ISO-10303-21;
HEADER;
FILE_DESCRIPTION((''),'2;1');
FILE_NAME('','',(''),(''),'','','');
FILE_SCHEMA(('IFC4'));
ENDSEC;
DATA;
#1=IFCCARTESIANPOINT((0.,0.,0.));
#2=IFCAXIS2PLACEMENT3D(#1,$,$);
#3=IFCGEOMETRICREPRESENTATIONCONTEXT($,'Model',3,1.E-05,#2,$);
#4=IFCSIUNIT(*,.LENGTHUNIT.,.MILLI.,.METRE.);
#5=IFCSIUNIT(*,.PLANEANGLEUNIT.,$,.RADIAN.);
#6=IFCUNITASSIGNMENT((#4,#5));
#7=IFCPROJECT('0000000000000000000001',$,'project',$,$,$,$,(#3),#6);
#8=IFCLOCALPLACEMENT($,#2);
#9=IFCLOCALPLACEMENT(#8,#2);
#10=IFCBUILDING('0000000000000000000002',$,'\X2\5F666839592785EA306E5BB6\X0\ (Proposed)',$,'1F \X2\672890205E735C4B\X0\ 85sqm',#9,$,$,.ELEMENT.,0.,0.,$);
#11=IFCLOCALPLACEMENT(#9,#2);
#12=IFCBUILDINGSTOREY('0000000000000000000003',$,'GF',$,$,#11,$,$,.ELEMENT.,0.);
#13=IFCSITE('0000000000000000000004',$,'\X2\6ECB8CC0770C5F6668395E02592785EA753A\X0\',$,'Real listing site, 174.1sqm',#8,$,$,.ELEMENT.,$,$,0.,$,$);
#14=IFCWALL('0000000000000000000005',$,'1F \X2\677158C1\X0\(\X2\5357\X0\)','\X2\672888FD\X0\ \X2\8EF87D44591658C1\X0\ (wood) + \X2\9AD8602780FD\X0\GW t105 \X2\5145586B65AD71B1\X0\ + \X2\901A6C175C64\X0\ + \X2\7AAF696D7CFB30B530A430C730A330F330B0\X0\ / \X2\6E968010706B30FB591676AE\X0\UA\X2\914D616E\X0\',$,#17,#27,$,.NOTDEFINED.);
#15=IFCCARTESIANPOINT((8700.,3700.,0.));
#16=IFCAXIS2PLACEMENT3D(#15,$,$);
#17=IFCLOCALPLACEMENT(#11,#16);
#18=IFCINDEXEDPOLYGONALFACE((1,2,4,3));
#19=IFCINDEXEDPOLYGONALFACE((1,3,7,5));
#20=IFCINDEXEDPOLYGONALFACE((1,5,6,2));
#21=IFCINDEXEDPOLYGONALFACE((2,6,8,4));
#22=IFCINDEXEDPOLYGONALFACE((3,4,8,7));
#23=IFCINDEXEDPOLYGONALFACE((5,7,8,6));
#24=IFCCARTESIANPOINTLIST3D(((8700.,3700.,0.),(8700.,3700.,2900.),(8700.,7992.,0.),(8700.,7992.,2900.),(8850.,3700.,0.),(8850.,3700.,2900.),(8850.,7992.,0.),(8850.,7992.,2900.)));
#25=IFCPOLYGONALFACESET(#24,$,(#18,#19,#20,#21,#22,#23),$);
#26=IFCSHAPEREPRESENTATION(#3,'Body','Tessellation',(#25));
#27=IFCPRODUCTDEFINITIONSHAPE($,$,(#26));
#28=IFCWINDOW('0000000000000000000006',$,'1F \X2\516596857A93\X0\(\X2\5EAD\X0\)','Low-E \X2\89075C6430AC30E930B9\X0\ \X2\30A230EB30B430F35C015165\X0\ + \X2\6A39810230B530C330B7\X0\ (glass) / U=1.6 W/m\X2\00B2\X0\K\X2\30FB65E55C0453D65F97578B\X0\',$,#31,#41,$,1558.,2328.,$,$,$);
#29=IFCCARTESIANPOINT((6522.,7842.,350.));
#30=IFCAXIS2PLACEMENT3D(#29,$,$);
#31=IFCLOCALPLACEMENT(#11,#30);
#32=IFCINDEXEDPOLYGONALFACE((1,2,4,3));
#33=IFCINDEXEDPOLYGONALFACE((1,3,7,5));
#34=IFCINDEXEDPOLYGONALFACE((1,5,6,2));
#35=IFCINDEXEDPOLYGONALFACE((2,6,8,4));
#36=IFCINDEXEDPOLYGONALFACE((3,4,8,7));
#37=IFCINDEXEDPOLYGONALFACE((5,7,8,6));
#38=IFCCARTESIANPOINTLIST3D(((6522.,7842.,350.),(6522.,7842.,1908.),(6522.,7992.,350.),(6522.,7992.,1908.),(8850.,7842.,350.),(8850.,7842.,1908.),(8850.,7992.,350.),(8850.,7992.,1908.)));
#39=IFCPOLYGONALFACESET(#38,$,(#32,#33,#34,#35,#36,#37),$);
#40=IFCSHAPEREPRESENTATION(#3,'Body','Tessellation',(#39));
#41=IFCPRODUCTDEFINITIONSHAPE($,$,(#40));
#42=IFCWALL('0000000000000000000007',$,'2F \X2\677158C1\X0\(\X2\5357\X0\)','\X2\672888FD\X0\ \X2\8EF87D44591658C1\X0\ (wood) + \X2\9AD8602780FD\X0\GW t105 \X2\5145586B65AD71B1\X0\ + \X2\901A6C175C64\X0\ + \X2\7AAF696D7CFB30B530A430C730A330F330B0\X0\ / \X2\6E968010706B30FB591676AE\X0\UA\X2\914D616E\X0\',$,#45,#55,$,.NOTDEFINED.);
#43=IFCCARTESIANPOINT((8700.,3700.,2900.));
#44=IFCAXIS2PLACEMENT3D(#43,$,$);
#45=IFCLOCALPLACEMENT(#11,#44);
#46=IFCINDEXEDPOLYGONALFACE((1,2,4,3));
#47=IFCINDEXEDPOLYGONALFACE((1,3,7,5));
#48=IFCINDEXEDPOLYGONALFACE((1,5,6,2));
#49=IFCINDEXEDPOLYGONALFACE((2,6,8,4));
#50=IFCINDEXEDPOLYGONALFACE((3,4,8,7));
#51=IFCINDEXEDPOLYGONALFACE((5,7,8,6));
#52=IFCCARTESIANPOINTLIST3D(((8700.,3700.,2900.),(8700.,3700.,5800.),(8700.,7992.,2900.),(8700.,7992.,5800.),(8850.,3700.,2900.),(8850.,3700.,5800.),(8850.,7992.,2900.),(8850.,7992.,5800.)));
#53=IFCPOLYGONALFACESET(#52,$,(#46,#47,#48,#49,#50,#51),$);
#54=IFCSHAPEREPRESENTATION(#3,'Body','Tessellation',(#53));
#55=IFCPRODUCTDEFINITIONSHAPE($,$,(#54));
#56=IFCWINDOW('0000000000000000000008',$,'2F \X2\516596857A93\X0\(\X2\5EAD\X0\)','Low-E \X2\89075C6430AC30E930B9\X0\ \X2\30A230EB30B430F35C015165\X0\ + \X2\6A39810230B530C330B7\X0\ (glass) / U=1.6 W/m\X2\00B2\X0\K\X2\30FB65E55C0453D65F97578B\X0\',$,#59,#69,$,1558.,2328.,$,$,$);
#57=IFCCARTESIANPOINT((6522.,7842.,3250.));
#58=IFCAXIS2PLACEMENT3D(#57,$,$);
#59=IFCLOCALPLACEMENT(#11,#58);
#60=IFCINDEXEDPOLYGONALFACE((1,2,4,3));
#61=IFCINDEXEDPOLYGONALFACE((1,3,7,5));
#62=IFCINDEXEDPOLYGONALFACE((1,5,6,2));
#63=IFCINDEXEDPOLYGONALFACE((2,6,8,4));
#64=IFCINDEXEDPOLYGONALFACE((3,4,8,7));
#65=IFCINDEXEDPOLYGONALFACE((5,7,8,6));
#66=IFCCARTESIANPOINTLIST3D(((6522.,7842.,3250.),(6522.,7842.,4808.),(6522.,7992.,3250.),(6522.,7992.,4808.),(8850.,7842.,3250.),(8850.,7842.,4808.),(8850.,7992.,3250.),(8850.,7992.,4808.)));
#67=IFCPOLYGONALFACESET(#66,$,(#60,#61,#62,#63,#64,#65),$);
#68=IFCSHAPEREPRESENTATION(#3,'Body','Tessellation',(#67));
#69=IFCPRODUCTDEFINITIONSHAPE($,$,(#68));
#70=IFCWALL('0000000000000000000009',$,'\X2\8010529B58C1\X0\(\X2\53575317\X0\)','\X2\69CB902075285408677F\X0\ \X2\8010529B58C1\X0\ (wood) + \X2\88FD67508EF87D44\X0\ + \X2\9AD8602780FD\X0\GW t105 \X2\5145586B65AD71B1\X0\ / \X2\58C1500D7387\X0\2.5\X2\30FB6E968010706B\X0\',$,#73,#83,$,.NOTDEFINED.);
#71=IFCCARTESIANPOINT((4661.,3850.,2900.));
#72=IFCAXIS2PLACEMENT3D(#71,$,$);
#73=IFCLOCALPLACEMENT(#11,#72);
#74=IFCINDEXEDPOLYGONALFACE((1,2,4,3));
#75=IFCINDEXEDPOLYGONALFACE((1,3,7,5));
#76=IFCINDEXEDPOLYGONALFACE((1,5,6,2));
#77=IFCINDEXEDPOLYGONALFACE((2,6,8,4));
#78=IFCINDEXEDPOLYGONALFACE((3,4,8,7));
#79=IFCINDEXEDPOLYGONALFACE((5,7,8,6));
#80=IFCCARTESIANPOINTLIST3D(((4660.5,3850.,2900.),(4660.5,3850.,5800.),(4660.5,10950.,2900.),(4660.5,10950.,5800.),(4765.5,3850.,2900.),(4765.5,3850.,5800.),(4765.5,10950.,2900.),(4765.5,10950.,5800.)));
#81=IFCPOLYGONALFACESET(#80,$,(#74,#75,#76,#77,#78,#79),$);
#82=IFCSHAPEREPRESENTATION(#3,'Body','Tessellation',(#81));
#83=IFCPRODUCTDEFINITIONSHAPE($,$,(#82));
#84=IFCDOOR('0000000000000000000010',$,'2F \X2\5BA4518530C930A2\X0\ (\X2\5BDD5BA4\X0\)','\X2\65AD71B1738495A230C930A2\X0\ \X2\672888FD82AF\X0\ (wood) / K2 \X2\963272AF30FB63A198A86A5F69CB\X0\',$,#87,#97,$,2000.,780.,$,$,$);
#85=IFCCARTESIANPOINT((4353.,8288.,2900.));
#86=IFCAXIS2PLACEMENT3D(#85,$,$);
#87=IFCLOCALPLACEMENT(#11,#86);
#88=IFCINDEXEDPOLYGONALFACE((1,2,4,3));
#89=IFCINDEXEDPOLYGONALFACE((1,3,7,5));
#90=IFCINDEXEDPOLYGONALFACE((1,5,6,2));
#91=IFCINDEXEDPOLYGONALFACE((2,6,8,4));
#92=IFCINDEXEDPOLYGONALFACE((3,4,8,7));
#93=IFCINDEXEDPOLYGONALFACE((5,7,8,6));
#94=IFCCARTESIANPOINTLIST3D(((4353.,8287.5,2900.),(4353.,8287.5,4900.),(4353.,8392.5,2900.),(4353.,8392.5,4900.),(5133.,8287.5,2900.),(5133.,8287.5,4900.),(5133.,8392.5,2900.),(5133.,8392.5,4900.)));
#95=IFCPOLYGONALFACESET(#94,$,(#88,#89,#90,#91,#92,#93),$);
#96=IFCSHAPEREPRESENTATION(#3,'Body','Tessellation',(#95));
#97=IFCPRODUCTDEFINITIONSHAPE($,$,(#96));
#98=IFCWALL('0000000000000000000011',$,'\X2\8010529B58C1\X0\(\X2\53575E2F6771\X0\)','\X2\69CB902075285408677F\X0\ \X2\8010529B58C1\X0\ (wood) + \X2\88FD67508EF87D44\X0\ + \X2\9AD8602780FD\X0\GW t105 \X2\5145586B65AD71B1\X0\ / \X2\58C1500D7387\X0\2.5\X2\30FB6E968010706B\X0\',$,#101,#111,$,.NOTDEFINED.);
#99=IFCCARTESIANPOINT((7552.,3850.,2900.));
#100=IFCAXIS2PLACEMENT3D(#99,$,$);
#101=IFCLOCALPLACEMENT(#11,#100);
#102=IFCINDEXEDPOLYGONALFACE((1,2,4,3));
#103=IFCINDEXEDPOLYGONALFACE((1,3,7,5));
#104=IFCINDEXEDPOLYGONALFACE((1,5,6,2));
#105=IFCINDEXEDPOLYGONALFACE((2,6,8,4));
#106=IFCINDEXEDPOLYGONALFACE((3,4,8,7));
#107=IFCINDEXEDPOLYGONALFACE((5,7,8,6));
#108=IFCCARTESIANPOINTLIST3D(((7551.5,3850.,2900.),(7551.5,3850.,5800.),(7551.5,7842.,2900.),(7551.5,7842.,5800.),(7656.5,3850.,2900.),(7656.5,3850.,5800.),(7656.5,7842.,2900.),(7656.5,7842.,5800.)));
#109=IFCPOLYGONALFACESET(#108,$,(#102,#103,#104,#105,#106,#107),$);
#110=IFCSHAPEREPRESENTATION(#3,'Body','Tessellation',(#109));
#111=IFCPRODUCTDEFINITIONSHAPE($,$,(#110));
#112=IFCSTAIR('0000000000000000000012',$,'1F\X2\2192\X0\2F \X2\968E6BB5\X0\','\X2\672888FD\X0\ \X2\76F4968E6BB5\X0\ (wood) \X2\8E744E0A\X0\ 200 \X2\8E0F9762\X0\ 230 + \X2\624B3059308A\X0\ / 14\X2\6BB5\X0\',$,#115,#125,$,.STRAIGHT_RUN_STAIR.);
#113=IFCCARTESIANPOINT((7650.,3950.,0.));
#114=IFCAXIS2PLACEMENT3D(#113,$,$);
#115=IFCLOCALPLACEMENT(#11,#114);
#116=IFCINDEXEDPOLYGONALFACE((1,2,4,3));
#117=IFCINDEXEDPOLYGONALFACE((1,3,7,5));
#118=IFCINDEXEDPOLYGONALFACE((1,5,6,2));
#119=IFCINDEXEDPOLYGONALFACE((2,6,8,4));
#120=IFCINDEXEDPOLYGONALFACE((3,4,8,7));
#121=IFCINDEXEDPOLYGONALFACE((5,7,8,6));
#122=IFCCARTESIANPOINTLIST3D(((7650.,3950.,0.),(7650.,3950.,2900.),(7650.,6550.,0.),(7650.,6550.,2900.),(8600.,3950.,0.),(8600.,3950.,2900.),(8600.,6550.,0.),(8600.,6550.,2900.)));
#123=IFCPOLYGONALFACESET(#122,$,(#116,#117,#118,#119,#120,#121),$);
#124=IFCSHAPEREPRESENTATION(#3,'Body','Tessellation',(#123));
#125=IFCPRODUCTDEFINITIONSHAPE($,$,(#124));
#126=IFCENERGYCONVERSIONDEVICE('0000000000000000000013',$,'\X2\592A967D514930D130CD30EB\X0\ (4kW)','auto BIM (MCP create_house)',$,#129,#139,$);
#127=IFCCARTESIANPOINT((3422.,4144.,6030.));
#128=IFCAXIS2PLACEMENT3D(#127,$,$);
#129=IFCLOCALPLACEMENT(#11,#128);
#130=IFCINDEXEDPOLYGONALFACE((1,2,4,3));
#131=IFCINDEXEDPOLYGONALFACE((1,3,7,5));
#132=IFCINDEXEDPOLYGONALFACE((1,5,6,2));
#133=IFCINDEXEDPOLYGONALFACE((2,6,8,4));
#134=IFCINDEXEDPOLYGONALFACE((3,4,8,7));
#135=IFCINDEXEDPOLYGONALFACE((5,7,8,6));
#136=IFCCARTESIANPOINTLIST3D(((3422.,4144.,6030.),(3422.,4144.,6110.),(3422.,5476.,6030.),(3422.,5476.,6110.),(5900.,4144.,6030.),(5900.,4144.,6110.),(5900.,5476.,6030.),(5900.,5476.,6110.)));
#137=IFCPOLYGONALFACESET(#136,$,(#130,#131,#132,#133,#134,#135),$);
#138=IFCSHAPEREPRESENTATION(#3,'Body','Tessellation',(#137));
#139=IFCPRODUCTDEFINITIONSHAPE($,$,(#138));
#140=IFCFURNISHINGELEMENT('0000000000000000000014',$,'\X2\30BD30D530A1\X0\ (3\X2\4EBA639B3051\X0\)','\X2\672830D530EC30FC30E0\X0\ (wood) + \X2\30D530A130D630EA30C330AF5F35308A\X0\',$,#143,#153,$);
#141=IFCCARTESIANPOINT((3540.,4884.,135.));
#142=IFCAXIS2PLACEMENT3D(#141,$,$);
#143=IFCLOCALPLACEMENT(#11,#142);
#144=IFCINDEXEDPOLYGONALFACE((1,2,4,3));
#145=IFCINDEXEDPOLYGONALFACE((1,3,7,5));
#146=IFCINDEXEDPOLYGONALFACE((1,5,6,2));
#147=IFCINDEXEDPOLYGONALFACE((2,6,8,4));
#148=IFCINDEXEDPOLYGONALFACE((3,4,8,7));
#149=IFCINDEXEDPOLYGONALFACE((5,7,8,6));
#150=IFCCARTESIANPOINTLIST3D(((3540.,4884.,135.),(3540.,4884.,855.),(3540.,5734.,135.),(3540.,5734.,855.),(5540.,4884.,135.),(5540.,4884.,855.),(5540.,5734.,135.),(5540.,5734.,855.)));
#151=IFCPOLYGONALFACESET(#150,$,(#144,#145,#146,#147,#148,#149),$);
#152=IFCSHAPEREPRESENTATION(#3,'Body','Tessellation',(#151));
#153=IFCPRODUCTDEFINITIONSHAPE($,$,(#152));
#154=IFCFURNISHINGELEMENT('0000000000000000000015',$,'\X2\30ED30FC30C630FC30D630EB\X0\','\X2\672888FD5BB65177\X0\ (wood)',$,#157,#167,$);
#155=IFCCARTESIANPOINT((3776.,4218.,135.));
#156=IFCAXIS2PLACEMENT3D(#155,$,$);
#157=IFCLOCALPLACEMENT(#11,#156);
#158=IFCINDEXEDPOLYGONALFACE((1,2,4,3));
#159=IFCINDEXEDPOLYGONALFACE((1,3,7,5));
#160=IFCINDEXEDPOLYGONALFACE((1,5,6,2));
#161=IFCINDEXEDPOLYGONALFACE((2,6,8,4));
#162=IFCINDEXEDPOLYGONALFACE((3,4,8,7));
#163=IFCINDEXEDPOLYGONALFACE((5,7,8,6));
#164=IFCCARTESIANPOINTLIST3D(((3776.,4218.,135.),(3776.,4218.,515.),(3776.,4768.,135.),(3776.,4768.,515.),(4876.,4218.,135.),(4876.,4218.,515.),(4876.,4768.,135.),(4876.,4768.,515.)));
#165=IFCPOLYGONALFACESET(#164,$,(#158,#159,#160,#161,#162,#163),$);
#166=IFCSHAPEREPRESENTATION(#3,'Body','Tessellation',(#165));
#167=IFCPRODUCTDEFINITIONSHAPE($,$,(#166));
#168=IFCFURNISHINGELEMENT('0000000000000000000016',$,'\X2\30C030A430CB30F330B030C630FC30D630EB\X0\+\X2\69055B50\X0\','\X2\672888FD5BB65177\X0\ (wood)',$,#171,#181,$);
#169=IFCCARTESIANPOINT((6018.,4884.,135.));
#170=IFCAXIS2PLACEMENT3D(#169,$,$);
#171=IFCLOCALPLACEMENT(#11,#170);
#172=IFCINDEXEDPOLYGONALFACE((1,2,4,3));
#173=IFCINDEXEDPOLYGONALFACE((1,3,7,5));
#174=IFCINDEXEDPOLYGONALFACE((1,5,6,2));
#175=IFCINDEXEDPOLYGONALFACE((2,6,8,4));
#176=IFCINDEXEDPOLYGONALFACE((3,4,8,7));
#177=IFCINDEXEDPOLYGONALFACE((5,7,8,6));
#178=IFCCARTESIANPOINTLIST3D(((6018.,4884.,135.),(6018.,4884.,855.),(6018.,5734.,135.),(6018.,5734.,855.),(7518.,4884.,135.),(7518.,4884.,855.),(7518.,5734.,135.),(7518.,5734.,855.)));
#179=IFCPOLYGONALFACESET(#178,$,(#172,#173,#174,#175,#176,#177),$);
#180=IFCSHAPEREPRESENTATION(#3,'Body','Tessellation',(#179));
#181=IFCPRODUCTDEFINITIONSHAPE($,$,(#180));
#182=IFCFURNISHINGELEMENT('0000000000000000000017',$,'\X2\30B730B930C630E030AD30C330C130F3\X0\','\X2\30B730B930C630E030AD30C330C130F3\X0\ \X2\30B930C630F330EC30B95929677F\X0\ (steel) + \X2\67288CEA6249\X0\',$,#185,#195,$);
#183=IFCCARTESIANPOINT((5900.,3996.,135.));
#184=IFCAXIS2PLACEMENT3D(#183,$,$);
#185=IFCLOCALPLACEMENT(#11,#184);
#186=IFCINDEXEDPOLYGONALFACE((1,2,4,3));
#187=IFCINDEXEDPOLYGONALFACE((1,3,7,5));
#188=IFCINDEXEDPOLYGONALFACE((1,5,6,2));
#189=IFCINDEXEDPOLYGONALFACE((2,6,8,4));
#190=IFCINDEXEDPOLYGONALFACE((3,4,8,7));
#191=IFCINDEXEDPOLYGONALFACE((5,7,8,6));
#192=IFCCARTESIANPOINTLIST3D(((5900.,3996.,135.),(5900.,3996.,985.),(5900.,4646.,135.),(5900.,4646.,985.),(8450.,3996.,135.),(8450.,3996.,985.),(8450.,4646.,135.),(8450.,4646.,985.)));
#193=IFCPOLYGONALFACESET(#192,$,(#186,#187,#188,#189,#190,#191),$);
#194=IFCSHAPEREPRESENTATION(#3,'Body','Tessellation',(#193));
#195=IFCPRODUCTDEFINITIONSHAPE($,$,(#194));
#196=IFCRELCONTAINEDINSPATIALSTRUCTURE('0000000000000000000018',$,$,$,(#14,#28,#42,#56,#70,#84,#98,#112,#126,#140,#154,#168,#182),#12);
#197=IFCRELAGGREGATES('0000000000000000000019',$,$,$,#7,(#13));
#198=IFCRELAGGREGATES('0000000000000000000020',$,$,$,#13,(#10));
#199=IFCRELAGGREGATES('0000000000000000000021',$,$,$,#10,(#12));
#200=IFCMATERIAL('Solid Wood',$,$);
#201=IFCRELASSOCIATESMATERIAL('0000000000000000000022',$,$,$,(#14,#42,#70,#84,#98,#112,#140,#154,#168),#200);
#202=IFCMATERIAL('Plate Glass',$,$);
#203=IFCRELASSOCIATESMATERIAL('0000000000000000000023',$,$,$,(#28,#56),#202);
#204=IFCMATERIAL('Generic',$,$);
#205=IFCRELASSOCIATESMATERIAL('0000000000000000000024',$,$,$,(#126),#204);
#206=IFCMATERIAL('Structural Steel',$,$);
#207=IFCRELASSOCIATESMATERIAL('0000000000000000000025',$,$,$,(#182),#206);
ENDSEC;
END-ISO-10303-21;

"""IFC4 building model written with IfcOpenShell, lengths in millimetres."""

from ifc_helpers import new_model, si_unit, frame, frame_2d, origin, place, context, project, spatial, rectangle, extrude, material, element, fill, save


model = new_model("IFC4")

# Units and contexts
model_context = context("Model", 3, precision=1e-05, world=origin())
ifc_project = project(units=[si_unit("LENGTHUNIT", "METRE", prefix="MILLI"), si_unit("PLANEANGLEUNIT", "RADIAN")], contexts=[model_context])

# Site, building, storey
site_placement = place(None, origin())
site = spatial("IfcSite", under=ifc_project, at=site_placement, Name="滋賀県彦根市大藪町", ObjectType="Real listing site, 174.1sqm", CompositionType="ELEMENT", RefElevation=0.0)
building_placement = place(site_placement, origin())
building = spatial("IfcBuilding", under=site, at=building_placement, Name="彦根大藪の家 (Proposed)", ObjectType="1F 木造平屋 85sqm", CompositionType="ELEMENT", ElevationOfRefHeight=0.0, ElevationOfTerrain=0.0)
storey_placement = place(building_placement, origin())
storey = spatial("IfcBuildingStorey", under=building, at=storey_placement, Name="GF", CompositionType="ELEMENT", Elevation=0.0)

# Wall, opening, window
ifc_material_1 = material(Name="Solid Wood")
wall_1_placement = place(storey_placement, frame((8700.0, 3700.0, 0.0)))
wall_1 = element("IfcWall", 1, at=wall_1_placement, inside=storey, material=ifc_material_1, Name="1F 東壁(南)", Description="木製 軸組外壁 (wood) + 高性能GW t105 充填断熱 + 通気層 + 窯業系サイディング / 準耐火・外皮UA配慮", PredefinedType="NOTDEFINED", context=model_context, shape_type="SweptSolid", body=[
    extrude(rectangle(XDim=150.0, YDim=4292.0, at=frame_2d((75.0, 2146.0))), frame((8700.0, 3700.0, 0.0)), (0.0, 0.0, 1.0), 2900.0),
])
opening_1_placement = place(storey_placement, frame((6522.0, 7842.0, 350.0)))
opening_1 = element("IfcOpeningElement", 2, at=opening_1_placement, cuts=wall_1, PredefinedType="NOTDEFINED", context=model_context, shape_type="SweptSolid", body=[
    extrude(rectangle(XDim=2328.0, YDim=150.0, at=frame_2d((1164.0, 75.0))), frame((6522.0, 7842.0, 350.0)), (0.0, 0.0, 1.0), 1558.0),
])
ifc_material_2 = material(Name="Plate Glass")
window_1_placement = place(storey_placement, frame((6522.0, 7842.0, 350.0)))
window_1 = element("IfcWindow", 3, at=window_1_placement, inside=storey, material=ifc_material_2, Name="1F 入隅窓(庭)", Description="Low-E 複層ガラス アルゴン封入 + 樹脂サッシ (glass) / U=1.6 W/m²K・日射取得型", OverallHeight=1558.0, OverallWidth=2328.0, context=model_context, shape_type="SweptSolid", body=[
    extrude(rectangle(XDim=2328.0, YDim=150.0, at=frame_2d((1164.0, 75.0))), frame((6522.0, 7842.0, 350.0)), (0.0, 0.0, 1.0), 1558.0),
])
fill(opening_1, window_1)

# Wall, opening, window
wall_2_placement = place(storey_placement, frame((8700.0, 3700.0, 2900.0)))
wall_2 = element("IfcWall", 4, at=wall_2_placement, inside=storey, material=ifc_material_1, Name="2F 東壁(南)", Description="木製 軸組外壁 (wood) + 高性能GW t105 充填断熱 + 通気層 + 窯業系サイディング / 準耐火・外皮UA配慮", PredefinedType="NOTDEFINED", context=model_context, shape_type="SweptSolid", body=[
    extrude(rectangle(XDim=150.0, YDim=4292.0, at=frame_2d((75.0, 2146.0))), frame((8700.0, 3700.0, 2900.0)), (0.0, 0.0, 1.0), 2900.0),
])
opening_2_placement = place(storey_placement, frame((6522.0, 7842.0, 3250.0)))
opening_2 = element("IfcOpeningElement", 5, at=opening_2_placement, cuts=wall_2, PredefinedType="NOTDEFINED", context=model_context, shape_type="SweptSolid", body=[
    extrude(rectangle(XDim=2328.0, YDim=150.0, at=frame_2d((1164.0, 75.0))), frame((6522.0, 7842.0, 3250.0)), (0.0, 0.0, 1.0), 1558.0),
])
window_2_placement = place(storey_placement, frame((6522.0, 7842.0, 3250.0)))
window_2 = element("IfcWindow", 6, at=window_2_placement, inside=storey, material=ifc_material_2, Name="2F 入隅窓(庭)", Description="Low-E 複層ガラス アルゴン封入 + 樹脂サッシ (glass) / U=1.6 W/m²K・日射取得型", OverallHeight=1558.0, OverallWidth=2328.0, context=model_context, shape_type="SweptSolid", body=[
    extrude(rectangle(XDim=2328.0, YDim=150.0, at=frame_2d((1164.0, 75.0))), frame((6522.0, 7842.0, 3250.0)), (0.0, 0.0, 1.0), 1558.0),
])
fill(opening_2, window_2)

# Wall, opening, door
wall_3_placement = place(storey_placement, frame((4661.0, 3850.0, 2900.0)))
wall_3 = element("IfcWall", 7, at=wall_3_placement, inside=storey, material=ifc_material_1, Name="耐力壁(南北)", Description="構造用合板 耐力壁 (wood) + 製材軸組 + 高性能GW t105 充填断熱 / 壁倍率2.5・準耐火", PredefinedType="NOTDEFINED", context=model_context, shape_type="SweptSolid", body=[
    extrude(rectangle(XDim=105.0, YDim=7100.0, at=frame_2d((52.0, 3550.0))), frame((4661.0, 3850.0, 2900.0)), (0.0, 0.0, 1.0), 2900.0),
])
opening_3_placement = place(storey_placement, frame((4353.0, 8288.0, 2900.0)))
opening_3 = element("IfcOpeningElement", 8, at=opening_3_placement, cuts=wall_3, PredefinedType="NOTDEFINED", context=model_context, shape_type="SweptSolid", body=[
    extrude(rectangle(XDim=780.0, YDim=105.0, at=frame_2d((390.0, 52.0))), frame((4353.0, 8288.0, 2900.0)), (0.0, 0.0, 1.0), 2000.0),
])
door_1_placement = place(storey_placement, frame((4353.0, 8288.0, 2900.0)))
door_1 = element("IfcDoor", 9, at=door_1_placement, inside=storey, material=ifc_material_1, Name="2F 室内ドア (寝室)", Description="断熱玄関ドア 木製芯 (wood) / K2 防犯・採風機構", OverallHeight=2000.0, OverallWidth=780.0, context=model_context, shape_type="SweptSolid", body=[
    extrude(rectangle(XDim=780.0, YDim=105.0, at=frame_2d((390.0, 52.0))), frame((4353.0, 8288.0, 2900.0)), (0.0, 0.0, 1.0), 2000.0),
])
fill(opening_3, door_1)

# Wall
wall_4_placement = place(storey_placement, frame((7552.0, 3850.0, 2900.0)))
element("IfcWall", 10, at=wall_4_placement, inside=storey, material=ifc_material_1, Name="耐力壁(南帯東)", Description="構造用合板 耐力壁 (wood) + 製材軸組 + 高性能GW t105 充填断熱 / 壁倍率2.5・準耐火", PredefinedType="NOTDEFINED", context=model_context, shape_type="SweptSolid", body=[
    extrude(rectangle(XDim=105.0, YDim=3992.0, at=frame_2d((52.0, 1996.0))), frame((7552.0, 3850.0, 2900.0)), (0.0, 0.0, 1.0), 2900.0),
])

# Stair
stair_placement = place(storey_placement, frame((7650.0, 3950.0, 0.0)))
element("IfcStair", 11, at=stair_placement, inside=storey, material=ifc_material_1, Name="1F→2F 階段", Description="木製 直階段 (wood) 蹴上 200 踏面 230 + 手すり / 14段", PredefinedType="STRAIGHT_RUN_STAIR", context=model_context, shape_type="SweptSolid", body=[
    extrude(rectangle(XDim=950.0, YDim=2600.0, at=frame_2d((475.0, 1300.0))), frame((7650.0, 3950.0, 0.0)), (0.0, 0.0, 1.0), 2900.0),
])

# Energy conversion device
ifc_material_3 = material(Name="Generic")
energy_conversion_device_placement = place(storey_placement, frame((3422.0, 4144.0, 6030.0)))
element("IfcEnergyConversionDevice", 12, at=energy_conversion_device_placement, inside=storey, material=ifc_material_3, Name="太陽光パネル (4kW)", Description="auto BIM (MCP create_house)", context=model_context, shape_type="SweptSolid", body=[
    extrude(rectangle(XDim=2478.0, YDim=1332.0, at=frame_2d((1239.0, 666.0))), frame((3422.0, 4144.0, 6030.0)), (0.0, 0.0, 1.0), 80.0),
])

# Furnishing elements
furnishing_1_placement = place(storey_placement, frame((3540.0, 4884.0, 135.0)))
element("IfcFurnishingElement", 13, at=furnishing_1_placement, inside=storey, material=ifc_material_1, Name="ソファ (3人掛け)", Description="木フレーム (wood) + ファブリック張り", context=model_context, shape_type="SweptSolid", body=[
    extrude(rectangle(XDim=2000.0, YDim=850.0, at=frame_2d((1000.0, 425.0))), frame((3540.0, 4884.0, 135.0)), (0.0, 0.0, 1.0), 720.0),
])
furnishing_2_placement = place(storey_placement, frame((3776.0, 4218.0, 135.0)))
element("IfcFurnishingElement", 14, at=furnishing_2_placement, inside=storey, material=ifc_material_1, Name="ローテーブル", Description="木製家具 (wood)", context=model_context, shape_type="SweptSolid", body=[
    extrude(rectangle(XDim=1100.0, YDim=550.0, at=frame_2d((550.0, 275.0))), frame((3776.0, 4218.0, 135.0)), (0.0, 0.0, 1.0), 380.0),
])
furnishing_3_placement = place(storey_placement, frame((6018.0, 4884.0, 135.0)))
element("IfcFurnishingElement", 15, at=furnishing_3_placement, inside=storey, material=ifc_material_1, Name="ダイニングテーブル+椅子", Description="木製家具 (wood)", context=model_context, shape_type="SweptSolid", body=[
    extrude(rectangle(XDim=1500.0, YDim=850.0, at=frame_2d((750.0, 425.0))), frame((6018.0, 4884.0, 135.0)), (0.0, 0.0, 1.0), 720.0),
])
ifc_material_4 = material(Name="Structural Steel")
furnishing_4_placement = place(storey_placement, frame((5900.0, 3996.0, 135.0)))
element("IfcFurnishingElement", 16, at=furnishing_4_placement, inside=storey, material=ifc_material_4, Name="システムキッチン", Description="システムキッチン ステンレス天板 (steel) + 木質扉", context=model_context, shape_type="SweptSolid", body=[
    extrude(rectangle(XDim=2550.0, YDim=650.0, at=frame_2d((1275.0, 325.0))), frame((5900.0, 3996.0, 135.0)), (0.0, 0.0, 1.0), 850.0),
])

save(model, "model.ifc")
